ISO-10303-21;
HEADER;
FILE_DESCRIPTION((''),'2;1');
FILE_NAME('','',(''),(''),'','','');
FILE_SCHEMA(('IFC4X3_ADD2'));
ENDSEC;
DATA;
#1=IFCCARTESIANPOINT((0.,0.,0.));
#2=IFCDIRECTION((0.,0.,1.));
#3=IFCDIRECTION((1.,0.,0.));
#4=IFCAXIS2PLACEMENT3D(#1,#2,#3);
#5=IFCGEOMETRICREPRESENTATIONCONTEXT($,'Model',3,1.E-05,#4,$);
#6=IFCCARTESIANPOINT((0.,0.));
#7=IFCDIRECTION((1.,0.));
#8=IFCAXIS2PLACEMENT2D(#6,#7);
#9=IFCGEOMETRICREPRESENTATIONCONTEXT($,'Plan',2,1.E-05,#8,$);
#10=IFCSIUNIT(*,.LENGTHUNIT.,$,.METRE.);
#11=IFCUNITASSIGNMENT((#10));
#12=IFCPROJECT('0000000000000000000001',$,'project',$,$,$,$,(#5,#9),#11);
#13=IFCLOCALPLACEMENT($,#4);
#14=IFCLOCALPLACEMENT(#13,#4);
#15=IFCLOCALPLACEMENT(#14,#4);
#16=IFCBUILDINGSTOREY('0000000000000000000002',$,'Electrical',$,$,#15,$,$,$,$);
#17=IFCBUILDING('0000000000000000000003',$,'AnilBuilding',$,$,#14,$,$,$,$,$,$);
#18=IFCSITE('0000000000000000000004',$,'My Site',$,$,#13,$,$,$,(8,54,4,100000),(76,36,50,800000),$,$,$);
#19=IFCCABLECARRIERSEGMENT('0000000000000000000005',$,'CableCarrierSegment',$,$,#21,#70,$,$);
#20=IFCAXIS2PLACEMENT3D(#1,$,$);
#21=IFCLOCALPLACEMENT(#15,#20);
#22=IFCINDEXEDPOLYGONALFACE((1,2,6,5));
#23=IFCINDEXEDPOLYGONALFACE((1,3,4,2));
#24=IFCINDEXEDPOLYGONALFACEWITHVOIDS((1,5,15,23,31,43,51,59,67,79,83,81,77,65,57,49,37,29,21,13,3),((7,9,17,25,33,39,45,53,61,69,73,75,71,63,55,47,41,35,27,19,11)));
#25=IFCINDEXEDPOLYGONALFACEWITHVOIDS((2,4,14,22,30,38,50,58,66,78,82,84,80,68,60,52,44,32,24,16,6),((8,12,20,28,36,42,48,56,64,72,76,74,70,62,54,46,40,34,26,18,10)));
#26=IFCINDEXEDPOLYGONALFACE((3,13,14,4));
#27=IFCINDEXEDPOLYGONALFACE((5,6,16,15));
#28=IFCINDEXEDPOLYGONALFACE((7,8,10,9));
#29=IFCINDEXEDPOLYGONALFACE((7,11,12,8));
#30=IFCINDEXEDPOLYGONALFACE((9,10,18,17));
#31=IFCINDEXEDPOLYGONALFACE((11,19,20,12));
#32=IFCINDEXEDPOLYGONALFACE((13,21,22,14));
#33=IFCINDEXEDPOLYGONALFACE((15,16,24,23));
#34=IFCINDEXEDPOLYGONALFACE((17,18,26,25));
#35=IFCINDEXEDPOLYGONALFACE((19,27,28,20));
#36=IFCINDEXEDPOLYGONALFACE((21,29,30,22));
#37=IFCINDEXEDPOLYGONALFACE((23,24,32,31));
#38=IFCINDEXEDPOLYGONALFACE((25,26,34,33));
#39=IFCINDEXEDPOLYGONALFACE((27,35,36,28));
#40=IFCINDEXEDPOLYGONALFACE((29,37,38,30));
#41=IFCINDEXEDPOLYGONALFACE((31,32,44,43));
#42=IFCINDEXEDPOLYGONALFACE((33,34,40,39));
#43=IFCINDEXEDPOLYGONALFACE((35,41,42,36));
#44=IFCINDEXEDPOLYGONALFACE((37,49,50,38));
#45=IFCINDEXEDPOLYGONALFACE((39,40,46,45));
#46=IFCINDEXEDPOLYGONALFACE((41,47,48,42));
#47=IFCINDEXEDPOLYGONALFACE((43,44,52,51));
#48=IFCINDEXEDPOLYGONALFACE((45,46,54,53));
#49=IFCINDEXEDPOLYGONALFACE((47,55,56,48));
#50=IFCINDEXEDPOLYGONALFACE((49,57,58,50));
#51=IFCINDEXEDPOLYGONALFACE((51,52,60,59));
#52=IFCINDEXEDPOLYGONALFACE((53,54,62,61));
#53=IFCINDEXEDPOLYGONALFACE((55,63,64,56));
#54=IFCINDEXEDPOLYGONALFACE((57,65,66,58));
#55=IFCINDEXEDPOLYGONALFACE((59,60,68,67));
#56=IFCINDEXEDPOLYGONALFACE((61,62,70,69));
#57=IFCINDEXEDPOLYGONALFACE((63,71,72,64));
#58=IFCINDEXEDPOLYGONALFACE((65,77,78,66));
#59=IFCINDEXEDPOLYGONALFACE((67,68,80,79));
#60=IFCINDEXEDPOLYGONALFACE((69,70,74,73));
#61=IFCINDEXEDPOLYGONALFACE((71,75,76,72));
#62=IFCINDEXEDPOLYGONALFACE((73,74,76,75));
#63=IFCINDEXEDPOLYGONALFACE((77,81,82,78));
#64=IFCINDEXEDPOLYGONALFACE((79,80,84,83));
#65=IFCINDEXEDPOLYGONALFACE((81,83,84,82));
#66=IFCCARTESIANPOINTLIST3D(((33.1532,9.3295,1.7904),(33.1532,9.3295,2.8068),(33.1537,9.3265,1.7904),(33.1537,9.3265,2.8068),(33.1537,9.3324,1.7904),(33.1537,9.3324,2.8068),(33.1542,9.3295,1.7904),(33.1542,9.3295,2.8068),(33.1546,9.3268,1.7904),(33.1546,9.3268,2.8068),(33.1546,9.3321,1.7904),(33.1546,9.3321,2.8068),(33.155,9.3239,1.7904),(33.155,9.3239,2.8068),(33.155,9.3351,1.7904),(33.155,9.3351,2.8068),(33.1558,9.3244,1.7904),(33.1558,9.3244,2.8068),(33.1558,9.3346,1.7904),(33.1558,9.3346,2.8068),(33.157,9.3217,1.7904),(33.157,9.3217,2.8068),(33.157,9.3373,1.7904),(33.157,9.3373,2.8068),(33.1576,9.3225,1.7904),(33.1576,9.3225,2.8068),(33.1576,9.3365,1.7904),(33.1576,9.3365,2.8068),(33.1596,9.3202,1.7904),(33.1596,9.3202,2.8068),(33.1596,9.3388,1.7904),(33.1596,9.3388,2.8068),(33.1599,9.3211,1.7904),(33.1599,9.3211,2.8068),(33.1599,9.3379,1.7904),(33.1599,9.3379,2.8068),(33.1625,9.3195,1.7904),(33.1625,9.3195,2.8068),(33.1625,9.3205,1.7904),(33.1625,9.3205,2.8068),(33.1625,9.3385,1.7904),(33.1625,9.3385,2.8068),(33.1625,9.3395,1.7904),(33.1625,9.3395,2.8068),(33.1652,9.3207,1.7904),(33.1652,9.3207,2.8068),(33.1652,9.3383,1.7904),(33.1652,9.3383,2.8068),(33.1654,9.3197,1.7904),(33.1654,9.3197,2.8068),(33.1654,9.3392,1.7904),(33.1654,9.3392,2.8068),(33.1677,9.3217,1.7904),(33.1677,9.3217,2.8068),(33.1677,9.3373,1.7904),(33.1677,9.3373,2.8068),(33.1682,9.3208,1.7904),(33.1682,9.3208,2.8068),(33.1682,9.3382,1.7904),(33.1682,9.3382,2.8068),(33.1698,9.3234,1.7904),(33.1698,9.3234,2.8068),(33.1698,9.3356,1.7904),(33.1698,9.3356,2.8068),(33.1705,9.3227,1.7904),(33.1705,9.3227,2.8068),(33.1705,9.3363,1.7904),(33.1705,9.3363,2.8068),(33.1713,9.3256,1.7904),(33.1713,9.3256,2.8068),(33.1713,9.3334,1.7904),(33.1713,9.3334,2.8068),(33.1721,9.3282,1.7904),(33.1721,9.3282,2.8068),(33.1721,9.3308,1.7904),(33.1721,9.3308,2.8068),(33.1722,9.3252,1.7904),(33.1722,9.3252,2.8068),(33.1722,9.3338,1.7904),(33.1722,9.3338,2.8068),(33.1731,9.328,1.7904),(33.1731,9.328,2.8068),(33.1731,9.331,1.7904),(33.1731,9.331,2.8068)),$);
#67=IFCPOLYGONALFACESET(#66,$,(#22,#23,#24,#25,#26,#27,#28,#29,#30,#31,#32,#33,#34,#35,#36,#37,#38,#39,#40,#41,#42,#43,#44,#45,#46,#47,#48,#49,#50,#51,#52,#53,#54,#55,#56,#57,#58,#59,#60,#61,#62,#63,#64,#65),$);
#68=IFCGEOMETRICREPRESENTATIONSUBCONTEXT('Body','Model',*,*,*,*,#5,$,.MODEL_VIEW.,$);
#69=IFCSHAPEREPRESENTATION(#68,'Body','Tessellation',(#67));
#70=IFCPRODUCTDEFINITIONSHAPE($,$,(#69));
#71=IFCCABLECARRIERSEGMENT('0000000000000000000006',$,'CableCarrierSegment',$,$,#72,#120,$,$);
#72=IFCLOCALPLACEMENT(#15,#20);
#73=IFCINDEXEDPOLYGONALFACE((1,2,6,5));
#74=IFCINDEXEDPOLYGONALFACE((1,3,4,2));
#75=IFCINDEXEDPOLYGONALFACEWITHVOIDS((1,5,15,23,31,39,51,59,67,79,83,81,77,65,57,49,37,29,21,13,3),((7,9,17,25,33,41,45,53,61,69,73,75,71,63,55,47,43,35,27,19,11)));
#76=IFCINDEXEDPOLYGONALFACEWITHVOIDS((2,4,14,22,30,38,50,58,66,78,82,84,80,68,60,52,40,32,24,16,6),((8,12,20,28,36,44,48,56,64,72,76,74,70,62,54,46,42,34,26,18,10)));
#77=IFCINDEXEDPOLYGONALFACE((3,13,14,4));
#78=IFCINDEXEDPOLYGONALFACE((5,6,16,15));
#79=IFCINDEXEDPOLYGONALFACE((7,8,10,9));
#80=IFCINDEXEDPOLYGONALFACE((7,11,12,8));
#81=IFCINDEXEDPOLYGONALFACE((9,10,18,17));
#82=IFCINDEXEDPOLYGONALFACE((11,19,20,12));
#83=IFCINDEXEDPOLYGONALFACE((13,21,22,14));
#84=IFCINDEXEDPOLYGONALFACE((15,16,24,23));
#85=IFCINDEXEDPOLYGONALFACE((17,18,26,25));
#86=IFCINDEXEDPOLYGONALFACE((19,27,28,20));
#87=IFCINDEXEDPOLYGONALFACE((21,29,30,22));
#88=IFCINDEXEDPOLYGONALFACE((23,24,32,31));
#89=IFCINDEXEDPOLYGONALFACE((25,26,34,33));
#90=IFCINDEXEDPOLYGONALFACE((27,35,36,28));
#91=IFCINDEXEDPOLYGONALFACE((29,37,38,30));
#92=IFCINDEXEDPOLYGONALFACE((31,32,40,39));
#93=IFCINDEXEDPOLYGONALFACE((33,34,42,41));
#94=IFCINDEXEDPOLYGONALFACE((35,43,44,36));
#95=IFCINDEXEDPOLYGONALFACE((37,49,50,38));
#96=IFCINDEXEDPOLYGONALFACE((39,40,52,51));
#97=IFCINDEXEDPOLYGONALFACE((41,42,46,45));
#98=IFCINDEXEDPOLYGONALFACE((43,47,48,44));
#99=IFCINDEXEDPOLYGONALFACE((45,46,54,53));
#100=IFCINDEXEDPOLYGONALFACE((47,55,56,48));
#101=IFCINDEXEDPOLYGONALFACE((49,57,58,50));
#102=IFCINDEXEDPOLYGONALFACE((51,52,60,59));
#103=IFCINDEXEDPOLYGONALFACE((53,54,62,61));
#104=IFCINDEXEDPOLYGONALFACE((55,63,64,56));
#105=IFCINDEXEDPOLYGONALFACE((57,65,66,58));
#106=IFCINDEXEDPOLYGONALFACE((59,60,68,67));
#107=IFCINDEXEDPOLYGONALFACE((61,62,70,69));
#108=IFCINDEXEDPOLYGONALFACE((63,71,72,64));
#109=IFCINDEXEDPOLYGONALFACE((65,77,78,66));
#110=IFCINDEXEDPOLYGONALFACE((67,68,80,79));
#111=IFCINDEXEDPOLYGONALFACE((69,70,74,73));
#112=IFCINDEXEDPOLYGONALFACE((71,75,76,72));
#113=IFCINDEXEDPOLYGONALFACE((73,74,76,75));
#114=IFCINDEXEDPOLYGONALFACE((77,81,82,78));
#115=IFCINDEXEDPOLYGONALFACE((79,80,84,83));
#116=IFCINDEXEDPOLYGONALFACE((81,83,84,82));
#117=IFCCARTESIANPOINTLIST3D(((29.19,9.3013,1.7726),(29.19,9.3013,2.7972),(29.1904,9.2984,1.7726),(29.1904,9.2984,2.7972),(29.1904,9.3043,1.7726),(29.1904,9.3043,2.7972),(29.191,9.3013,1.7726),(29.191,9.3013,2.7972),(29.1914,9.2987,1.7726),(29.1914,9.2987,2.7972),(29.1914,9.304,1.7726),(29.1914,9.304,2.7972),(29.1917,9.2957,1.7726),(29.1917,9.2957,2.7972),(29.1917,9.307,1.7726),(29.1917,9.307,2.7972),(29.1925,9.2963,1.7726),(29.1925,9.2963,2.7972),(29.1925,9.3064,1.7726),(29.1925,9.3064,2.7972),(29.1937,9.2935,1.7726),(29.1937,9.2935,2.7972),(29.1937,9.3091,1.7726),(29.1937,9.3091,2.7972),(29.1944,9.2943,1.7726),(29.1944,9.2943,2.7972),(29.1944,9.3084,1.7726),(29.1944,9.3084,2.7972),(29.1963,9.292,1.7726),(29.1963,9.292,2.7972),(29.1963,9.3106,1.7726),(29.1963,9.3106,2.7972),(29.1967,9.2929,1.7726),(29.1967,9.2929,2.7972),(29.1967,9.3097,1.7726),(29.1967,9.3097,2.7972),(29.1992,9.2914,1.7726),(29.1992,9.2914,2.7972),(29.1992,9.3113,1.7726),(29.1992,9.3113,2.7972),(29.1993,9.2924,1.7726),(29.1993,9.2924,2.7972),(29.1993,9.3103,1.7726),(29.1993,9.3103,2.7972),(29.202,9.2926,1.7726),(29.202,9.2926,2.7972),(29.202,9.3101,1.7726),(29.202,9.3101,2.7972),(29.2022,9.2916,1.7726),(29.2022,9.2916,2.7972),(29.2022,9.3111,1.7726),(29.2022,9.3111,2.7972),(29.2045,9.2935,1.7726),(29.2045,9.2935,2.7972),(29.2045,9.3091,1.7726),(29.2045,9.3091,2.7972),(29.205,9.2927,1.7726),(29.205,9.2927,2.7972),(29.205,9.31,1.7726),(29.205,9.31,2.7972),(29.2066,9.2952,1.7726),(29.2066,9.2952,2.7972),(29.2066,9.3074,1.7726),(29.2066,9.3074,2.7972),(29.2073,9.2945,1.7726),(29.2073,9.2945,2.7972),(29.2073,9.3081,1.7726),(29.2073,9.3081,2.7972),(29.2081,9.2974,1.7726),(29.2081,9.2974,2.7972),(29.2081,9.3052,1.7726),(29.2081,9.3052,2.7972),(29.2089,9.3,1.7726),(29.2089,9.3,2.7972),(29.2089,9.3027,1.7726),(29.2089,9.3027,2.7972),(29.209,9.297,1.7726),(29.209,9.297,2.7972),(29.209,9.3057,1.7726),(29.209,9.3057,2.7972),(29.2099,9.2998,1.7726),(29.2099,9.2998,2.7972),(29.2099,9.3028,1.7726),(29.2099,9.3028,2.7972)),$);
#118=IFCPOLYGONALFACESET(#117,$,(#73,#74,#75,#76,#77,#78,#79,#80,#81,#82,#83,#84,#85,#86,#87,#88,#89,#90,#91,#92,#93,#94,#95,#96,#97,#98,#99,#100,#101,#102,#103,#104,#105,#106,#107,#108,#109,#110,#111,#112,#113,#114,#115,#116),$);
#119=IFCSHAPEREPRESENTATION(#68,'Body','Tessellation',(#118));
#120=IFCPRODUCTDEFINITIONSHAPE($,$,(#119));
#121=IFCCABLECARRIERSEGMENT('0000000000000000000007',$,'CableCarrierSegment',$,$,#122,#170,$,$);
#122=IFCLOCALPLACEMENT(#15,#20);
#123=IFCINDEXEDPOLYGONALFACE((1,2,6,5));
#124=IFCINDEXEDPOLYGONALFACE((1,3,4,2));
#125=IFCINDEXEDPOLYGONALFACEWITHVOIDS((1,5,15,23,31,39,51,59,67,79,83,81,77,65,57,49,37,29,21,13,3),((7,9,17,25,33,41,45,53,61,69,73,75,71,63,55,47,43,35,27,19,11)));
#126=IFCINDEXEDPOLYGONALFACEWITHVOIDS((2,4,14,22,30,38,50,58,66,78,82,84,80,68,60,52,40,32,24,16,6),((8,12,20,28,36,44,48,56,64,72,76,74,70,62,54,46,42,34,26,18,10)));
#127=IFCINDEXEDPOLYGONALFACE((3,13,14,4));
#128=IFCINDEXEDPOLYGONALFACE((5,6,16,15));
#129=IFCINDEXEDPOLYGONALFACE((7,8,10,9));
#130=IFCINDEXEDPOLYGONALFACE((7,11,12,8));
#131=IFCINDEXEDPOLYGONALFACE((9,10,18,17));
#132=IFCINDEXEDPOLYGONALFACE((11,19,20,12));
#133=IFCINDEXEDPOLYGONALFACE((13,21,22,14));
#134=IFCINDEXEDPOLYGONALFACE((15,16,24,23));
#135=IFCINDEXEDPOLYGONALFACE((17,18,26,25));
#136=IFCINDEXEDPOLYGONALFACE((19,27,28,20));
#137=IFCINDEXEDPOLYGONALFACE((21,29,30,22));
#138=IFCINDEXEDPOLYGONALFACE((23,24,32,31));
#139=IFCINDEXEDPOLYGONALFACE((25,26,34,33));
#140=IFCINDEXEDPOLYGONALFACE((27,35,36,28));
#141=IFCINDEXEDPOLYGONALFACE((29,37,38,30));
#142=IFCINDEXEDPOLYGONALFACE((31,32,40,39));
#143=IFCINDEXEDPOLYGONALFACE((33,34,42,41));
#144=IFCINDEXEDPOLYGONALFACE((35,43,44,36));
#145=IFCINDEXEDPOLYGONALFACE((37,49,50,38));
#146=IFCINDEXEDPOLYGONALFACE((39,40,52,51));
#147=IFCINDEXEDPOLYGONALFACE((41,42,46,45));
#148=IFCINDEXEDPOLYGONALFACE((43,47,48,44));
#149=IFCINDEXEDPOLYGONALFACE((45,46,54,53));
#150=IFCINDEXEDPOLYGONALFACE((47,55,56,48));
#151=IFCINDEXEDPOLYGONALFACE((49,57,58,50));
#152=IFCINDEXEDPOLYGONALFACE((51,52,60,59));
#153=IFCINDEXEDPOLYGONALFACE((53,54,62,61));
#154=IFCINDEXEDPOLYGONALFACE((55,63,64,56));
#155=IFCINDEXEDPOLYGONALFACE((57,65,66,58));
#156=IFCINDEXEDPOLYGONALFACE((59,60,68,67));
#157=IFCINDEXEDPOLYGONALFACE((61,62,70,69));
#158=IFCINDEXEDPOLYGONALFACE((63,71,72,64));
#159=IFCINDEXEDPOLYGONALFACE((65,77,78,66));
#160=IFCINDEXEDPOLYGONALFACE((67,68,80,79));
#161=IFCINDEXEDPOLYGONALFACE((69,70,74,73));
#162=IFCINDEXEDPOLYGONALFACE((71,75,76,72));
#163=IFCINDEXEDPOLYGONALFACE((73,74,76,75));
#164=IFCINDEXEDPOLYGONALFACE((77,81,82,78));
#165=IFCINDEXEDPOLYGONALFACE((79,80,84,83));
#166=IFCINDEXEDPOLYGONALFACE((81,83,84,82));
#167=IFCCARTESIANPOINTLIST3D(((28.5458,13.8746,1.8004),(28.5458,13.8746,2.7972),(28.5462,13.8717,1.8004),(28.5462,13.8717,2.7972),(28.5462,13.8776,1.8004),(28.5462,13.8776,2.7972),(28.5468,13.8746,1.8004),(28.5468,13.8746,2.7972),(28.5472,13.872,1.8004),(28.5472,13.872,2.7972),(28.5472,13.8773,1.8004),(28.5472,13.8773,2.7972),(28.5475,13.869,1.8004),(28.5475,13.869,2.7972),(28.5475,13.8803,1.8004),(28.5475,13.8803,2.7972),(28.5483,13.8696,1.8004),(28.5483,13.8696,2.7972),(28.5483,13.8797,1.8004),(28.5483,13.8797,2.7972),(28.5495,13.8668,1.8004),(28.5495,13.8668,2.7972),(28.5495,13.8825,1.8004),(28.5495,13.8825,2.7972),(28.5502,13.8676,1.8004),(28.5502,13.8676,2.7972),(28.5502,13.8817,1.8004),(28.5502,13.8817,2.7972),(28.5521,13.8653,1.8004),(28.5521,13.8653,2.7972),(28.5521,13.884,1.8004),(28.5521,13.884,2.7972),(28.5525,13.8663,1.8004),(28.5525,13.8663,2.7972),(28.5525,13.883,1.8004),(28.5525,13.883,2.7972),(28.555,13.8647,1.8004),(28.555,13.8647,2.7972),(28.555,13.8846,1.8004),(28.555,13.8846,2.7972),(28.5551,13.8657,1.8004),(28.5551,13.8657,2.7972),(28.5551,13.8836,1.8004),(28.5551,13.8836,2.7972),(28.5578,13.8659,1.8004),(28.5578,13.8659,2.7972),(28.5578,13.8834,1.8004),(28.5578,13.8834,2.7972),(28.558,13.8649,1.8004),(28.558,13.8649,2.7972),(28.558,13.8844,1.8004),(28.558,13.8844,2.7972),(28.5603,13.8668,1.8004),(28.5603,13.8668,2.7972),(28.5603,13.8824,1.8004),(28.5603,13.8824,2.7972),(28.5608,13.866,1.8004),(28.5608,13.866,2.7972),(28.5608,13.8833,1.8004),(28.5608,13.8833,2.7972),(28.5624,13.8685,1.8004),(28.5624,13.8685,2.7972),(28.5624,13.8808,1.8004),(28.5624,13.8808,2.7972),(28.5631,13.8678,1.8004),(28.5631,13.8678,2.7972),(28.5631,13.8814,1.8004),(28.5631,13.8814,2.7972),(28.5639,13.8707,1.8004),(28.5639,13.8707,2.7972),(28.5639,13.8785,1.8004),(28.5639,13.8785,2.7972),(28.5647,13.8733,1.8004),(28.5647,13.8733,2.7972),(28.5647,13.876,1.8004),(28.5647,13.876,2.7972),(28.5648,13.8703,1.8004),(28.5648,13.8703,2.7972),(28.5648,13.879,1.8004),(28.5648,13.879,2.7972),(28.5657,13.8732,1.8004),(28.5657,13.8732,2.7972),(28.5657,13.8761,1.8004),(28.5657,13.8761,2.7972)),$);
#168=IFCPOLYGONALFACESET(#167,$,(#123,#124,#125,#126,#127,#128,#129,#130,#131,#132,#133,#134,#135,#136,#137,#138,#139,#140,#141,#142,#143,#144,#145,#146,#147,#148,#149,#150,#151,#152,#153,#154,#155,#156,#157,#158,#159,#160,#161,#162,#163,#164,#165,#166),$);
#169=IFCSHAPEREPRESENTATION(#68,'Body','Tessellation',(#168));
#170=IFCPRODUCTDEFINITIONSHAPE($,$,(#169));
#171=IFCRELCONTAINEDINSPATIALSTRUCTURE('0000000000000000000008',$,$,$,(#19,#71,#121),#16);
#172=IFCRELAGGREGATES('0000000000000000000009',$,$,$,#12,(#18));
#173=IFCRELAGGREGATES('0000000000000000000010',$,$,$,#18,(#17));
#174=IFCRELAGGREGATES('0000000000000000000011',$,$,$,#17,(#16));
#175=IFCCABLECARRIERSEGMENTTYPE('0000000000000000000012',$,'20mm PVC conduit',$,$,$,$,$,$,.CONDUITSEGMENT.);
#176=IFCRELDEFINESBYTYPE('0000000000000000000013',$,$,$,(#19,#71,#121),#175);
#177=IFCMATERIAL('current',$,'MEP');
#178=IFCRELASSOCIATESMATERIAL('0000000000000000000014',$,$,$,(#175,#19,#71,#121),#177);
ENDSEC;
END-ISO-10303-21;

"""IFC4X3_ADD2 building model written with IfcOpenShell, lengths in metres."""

from ifc_helpers import new_model, si_unit, frame, origin_with_axes, origin_2d_with_axis, place, context, subcontext, project, spatial, hollow_circle, extrude, material, material_profile, profile_set, profile_usage, type_object, element, save


model = new_model("IFC4X3_ADD2")

# Units and contexts
model_context = context("Model", 3, precision=1e-05, world=origin_with_axes())
plan_context = context("Plan", 2, precision=1e-05, world=origin_2d_with_axis())
body_context = subcontext(model_context, "Body", "Model", "MODEL_VIEW")
ifc_project = project(units=[si_unit("LENGTHUNIT", "METRE")], contexts=[model_context, plan_context])

# Site, building, storey
site_placement = place(None, origin_with_axes())
site = spatial("IfcSite", under=ifc_project, at=site_placement, Name="My Site", RefLatitude=(8, 54, 4, 100000), RefLongitude=(76, 36, 50, 800000))
building_placement = place(site_placement, origin_with_axes())
building = spatial("IfcBuilding", under=site, at=building_placement, Name="AnilBuilding")
storey_placement = place(building_placement, origin_with_axes())
storey = spatial("IfcBuildingStorey", under=building, at=storey_placement, Name="Electrical")

# Cable carrier segments
ifc_material = material(Name="current", Category="MEP")
ifc_material_profile_1 = material_profile(ifc_material, hollow_circle(Radius=0.01, WallThickness=0.001))
ifc_profile_set_1 = profile_set([ifc_material_profile_1], Name="current")
ifc_material_profile_2 = material_profile(ifc_material, hollow_circle(Radius=0.01, WallThickness=0.001))
ifc_profile_set_2 = profile_set([ifc_material_profile_2], Name="current")
cable_carrier_segment_type = type_object("IfcCableCarrierSegmentType", Name="20mm PVC conduit", PredefinedType="CONDUITSEGMENT", material=ifc_profile_set_2)
ifc_profile_usage_1 = profile_usage(ifc_profile_set_1, cardinal=5)
cable_carrier_segment_1_placement = place(storey_placement, frame((33.1632, 9.3295, 1.7904), z_axis=(0.0, 0.0, 1.0), x_axis=(-1.0, 0.0, 0.0)))
element("IfcCableCarrierSegment", 1, at=cable_carrier_segment_1_placement, inside=storey, type_object=cable_carrier_segment_type, material=ifc_profile_usage_1, Name="CableCarrierSegment", context=body_context, shape_type="SweptSolid", body=[
    extrude(hollow_circle(Radius=0.01, WallThickness=0.001), origin_with_axes(), (0.0, 0.0, 1.0), 1.0164),
])
ifc_profile_usage_2 = profile_usage(ifc_profile_set_1, cardinal=5)
cable_carrier_segment_2_placement = place(storey_placement, frame((29.2, 9.3013, 1.7726), z_axis=(0.0, 0.0, 1.0), x_axis=(-1.0, 0.0, 0.0)))
element("IfcCableCarrierSegment", 2, at=cable_carrier_segment_2_placement, inside=storey, type_object=cable_carrier_segment_type, material=ifc_profile_usage_2, Name="CableCarrierSegment", context=body_context, shape_type="SweptSolid", body=[
    extrude(hollow_circle(Radius=0.01, WallThickness=0.001), origin_with_axes(), (0.0, 0.0, 1.0), 1.0246),
])
ifc_profile_usage_3 = profile_usage(ifc_profile_set_1, cardinal=5)
cable_carrier_segment_3_placement = place(storey_placement, frame((28.5558, 13.8746, 1.8004), z_axis=(0.0, 0.0, 1.0), x_axis=(-1.0, 0.0, 0.0)))
element("IfcCableCarrierSegment", 3, at=cable_carrier_segment_3_placement, inside=storey, type_object=cable_carrier_segment_type, material=ifc_profile_usage_3, Name="CableCarrierSegment", context=body_context, shape_type="SweptSolid", body=[
    extrude(hollow_circle(Radius=0.01, WallThickness=0.001), origin_with_axes(), (0.0, 0.0, 1.0), 0.9968),
])

save(model, "model.ifc")
